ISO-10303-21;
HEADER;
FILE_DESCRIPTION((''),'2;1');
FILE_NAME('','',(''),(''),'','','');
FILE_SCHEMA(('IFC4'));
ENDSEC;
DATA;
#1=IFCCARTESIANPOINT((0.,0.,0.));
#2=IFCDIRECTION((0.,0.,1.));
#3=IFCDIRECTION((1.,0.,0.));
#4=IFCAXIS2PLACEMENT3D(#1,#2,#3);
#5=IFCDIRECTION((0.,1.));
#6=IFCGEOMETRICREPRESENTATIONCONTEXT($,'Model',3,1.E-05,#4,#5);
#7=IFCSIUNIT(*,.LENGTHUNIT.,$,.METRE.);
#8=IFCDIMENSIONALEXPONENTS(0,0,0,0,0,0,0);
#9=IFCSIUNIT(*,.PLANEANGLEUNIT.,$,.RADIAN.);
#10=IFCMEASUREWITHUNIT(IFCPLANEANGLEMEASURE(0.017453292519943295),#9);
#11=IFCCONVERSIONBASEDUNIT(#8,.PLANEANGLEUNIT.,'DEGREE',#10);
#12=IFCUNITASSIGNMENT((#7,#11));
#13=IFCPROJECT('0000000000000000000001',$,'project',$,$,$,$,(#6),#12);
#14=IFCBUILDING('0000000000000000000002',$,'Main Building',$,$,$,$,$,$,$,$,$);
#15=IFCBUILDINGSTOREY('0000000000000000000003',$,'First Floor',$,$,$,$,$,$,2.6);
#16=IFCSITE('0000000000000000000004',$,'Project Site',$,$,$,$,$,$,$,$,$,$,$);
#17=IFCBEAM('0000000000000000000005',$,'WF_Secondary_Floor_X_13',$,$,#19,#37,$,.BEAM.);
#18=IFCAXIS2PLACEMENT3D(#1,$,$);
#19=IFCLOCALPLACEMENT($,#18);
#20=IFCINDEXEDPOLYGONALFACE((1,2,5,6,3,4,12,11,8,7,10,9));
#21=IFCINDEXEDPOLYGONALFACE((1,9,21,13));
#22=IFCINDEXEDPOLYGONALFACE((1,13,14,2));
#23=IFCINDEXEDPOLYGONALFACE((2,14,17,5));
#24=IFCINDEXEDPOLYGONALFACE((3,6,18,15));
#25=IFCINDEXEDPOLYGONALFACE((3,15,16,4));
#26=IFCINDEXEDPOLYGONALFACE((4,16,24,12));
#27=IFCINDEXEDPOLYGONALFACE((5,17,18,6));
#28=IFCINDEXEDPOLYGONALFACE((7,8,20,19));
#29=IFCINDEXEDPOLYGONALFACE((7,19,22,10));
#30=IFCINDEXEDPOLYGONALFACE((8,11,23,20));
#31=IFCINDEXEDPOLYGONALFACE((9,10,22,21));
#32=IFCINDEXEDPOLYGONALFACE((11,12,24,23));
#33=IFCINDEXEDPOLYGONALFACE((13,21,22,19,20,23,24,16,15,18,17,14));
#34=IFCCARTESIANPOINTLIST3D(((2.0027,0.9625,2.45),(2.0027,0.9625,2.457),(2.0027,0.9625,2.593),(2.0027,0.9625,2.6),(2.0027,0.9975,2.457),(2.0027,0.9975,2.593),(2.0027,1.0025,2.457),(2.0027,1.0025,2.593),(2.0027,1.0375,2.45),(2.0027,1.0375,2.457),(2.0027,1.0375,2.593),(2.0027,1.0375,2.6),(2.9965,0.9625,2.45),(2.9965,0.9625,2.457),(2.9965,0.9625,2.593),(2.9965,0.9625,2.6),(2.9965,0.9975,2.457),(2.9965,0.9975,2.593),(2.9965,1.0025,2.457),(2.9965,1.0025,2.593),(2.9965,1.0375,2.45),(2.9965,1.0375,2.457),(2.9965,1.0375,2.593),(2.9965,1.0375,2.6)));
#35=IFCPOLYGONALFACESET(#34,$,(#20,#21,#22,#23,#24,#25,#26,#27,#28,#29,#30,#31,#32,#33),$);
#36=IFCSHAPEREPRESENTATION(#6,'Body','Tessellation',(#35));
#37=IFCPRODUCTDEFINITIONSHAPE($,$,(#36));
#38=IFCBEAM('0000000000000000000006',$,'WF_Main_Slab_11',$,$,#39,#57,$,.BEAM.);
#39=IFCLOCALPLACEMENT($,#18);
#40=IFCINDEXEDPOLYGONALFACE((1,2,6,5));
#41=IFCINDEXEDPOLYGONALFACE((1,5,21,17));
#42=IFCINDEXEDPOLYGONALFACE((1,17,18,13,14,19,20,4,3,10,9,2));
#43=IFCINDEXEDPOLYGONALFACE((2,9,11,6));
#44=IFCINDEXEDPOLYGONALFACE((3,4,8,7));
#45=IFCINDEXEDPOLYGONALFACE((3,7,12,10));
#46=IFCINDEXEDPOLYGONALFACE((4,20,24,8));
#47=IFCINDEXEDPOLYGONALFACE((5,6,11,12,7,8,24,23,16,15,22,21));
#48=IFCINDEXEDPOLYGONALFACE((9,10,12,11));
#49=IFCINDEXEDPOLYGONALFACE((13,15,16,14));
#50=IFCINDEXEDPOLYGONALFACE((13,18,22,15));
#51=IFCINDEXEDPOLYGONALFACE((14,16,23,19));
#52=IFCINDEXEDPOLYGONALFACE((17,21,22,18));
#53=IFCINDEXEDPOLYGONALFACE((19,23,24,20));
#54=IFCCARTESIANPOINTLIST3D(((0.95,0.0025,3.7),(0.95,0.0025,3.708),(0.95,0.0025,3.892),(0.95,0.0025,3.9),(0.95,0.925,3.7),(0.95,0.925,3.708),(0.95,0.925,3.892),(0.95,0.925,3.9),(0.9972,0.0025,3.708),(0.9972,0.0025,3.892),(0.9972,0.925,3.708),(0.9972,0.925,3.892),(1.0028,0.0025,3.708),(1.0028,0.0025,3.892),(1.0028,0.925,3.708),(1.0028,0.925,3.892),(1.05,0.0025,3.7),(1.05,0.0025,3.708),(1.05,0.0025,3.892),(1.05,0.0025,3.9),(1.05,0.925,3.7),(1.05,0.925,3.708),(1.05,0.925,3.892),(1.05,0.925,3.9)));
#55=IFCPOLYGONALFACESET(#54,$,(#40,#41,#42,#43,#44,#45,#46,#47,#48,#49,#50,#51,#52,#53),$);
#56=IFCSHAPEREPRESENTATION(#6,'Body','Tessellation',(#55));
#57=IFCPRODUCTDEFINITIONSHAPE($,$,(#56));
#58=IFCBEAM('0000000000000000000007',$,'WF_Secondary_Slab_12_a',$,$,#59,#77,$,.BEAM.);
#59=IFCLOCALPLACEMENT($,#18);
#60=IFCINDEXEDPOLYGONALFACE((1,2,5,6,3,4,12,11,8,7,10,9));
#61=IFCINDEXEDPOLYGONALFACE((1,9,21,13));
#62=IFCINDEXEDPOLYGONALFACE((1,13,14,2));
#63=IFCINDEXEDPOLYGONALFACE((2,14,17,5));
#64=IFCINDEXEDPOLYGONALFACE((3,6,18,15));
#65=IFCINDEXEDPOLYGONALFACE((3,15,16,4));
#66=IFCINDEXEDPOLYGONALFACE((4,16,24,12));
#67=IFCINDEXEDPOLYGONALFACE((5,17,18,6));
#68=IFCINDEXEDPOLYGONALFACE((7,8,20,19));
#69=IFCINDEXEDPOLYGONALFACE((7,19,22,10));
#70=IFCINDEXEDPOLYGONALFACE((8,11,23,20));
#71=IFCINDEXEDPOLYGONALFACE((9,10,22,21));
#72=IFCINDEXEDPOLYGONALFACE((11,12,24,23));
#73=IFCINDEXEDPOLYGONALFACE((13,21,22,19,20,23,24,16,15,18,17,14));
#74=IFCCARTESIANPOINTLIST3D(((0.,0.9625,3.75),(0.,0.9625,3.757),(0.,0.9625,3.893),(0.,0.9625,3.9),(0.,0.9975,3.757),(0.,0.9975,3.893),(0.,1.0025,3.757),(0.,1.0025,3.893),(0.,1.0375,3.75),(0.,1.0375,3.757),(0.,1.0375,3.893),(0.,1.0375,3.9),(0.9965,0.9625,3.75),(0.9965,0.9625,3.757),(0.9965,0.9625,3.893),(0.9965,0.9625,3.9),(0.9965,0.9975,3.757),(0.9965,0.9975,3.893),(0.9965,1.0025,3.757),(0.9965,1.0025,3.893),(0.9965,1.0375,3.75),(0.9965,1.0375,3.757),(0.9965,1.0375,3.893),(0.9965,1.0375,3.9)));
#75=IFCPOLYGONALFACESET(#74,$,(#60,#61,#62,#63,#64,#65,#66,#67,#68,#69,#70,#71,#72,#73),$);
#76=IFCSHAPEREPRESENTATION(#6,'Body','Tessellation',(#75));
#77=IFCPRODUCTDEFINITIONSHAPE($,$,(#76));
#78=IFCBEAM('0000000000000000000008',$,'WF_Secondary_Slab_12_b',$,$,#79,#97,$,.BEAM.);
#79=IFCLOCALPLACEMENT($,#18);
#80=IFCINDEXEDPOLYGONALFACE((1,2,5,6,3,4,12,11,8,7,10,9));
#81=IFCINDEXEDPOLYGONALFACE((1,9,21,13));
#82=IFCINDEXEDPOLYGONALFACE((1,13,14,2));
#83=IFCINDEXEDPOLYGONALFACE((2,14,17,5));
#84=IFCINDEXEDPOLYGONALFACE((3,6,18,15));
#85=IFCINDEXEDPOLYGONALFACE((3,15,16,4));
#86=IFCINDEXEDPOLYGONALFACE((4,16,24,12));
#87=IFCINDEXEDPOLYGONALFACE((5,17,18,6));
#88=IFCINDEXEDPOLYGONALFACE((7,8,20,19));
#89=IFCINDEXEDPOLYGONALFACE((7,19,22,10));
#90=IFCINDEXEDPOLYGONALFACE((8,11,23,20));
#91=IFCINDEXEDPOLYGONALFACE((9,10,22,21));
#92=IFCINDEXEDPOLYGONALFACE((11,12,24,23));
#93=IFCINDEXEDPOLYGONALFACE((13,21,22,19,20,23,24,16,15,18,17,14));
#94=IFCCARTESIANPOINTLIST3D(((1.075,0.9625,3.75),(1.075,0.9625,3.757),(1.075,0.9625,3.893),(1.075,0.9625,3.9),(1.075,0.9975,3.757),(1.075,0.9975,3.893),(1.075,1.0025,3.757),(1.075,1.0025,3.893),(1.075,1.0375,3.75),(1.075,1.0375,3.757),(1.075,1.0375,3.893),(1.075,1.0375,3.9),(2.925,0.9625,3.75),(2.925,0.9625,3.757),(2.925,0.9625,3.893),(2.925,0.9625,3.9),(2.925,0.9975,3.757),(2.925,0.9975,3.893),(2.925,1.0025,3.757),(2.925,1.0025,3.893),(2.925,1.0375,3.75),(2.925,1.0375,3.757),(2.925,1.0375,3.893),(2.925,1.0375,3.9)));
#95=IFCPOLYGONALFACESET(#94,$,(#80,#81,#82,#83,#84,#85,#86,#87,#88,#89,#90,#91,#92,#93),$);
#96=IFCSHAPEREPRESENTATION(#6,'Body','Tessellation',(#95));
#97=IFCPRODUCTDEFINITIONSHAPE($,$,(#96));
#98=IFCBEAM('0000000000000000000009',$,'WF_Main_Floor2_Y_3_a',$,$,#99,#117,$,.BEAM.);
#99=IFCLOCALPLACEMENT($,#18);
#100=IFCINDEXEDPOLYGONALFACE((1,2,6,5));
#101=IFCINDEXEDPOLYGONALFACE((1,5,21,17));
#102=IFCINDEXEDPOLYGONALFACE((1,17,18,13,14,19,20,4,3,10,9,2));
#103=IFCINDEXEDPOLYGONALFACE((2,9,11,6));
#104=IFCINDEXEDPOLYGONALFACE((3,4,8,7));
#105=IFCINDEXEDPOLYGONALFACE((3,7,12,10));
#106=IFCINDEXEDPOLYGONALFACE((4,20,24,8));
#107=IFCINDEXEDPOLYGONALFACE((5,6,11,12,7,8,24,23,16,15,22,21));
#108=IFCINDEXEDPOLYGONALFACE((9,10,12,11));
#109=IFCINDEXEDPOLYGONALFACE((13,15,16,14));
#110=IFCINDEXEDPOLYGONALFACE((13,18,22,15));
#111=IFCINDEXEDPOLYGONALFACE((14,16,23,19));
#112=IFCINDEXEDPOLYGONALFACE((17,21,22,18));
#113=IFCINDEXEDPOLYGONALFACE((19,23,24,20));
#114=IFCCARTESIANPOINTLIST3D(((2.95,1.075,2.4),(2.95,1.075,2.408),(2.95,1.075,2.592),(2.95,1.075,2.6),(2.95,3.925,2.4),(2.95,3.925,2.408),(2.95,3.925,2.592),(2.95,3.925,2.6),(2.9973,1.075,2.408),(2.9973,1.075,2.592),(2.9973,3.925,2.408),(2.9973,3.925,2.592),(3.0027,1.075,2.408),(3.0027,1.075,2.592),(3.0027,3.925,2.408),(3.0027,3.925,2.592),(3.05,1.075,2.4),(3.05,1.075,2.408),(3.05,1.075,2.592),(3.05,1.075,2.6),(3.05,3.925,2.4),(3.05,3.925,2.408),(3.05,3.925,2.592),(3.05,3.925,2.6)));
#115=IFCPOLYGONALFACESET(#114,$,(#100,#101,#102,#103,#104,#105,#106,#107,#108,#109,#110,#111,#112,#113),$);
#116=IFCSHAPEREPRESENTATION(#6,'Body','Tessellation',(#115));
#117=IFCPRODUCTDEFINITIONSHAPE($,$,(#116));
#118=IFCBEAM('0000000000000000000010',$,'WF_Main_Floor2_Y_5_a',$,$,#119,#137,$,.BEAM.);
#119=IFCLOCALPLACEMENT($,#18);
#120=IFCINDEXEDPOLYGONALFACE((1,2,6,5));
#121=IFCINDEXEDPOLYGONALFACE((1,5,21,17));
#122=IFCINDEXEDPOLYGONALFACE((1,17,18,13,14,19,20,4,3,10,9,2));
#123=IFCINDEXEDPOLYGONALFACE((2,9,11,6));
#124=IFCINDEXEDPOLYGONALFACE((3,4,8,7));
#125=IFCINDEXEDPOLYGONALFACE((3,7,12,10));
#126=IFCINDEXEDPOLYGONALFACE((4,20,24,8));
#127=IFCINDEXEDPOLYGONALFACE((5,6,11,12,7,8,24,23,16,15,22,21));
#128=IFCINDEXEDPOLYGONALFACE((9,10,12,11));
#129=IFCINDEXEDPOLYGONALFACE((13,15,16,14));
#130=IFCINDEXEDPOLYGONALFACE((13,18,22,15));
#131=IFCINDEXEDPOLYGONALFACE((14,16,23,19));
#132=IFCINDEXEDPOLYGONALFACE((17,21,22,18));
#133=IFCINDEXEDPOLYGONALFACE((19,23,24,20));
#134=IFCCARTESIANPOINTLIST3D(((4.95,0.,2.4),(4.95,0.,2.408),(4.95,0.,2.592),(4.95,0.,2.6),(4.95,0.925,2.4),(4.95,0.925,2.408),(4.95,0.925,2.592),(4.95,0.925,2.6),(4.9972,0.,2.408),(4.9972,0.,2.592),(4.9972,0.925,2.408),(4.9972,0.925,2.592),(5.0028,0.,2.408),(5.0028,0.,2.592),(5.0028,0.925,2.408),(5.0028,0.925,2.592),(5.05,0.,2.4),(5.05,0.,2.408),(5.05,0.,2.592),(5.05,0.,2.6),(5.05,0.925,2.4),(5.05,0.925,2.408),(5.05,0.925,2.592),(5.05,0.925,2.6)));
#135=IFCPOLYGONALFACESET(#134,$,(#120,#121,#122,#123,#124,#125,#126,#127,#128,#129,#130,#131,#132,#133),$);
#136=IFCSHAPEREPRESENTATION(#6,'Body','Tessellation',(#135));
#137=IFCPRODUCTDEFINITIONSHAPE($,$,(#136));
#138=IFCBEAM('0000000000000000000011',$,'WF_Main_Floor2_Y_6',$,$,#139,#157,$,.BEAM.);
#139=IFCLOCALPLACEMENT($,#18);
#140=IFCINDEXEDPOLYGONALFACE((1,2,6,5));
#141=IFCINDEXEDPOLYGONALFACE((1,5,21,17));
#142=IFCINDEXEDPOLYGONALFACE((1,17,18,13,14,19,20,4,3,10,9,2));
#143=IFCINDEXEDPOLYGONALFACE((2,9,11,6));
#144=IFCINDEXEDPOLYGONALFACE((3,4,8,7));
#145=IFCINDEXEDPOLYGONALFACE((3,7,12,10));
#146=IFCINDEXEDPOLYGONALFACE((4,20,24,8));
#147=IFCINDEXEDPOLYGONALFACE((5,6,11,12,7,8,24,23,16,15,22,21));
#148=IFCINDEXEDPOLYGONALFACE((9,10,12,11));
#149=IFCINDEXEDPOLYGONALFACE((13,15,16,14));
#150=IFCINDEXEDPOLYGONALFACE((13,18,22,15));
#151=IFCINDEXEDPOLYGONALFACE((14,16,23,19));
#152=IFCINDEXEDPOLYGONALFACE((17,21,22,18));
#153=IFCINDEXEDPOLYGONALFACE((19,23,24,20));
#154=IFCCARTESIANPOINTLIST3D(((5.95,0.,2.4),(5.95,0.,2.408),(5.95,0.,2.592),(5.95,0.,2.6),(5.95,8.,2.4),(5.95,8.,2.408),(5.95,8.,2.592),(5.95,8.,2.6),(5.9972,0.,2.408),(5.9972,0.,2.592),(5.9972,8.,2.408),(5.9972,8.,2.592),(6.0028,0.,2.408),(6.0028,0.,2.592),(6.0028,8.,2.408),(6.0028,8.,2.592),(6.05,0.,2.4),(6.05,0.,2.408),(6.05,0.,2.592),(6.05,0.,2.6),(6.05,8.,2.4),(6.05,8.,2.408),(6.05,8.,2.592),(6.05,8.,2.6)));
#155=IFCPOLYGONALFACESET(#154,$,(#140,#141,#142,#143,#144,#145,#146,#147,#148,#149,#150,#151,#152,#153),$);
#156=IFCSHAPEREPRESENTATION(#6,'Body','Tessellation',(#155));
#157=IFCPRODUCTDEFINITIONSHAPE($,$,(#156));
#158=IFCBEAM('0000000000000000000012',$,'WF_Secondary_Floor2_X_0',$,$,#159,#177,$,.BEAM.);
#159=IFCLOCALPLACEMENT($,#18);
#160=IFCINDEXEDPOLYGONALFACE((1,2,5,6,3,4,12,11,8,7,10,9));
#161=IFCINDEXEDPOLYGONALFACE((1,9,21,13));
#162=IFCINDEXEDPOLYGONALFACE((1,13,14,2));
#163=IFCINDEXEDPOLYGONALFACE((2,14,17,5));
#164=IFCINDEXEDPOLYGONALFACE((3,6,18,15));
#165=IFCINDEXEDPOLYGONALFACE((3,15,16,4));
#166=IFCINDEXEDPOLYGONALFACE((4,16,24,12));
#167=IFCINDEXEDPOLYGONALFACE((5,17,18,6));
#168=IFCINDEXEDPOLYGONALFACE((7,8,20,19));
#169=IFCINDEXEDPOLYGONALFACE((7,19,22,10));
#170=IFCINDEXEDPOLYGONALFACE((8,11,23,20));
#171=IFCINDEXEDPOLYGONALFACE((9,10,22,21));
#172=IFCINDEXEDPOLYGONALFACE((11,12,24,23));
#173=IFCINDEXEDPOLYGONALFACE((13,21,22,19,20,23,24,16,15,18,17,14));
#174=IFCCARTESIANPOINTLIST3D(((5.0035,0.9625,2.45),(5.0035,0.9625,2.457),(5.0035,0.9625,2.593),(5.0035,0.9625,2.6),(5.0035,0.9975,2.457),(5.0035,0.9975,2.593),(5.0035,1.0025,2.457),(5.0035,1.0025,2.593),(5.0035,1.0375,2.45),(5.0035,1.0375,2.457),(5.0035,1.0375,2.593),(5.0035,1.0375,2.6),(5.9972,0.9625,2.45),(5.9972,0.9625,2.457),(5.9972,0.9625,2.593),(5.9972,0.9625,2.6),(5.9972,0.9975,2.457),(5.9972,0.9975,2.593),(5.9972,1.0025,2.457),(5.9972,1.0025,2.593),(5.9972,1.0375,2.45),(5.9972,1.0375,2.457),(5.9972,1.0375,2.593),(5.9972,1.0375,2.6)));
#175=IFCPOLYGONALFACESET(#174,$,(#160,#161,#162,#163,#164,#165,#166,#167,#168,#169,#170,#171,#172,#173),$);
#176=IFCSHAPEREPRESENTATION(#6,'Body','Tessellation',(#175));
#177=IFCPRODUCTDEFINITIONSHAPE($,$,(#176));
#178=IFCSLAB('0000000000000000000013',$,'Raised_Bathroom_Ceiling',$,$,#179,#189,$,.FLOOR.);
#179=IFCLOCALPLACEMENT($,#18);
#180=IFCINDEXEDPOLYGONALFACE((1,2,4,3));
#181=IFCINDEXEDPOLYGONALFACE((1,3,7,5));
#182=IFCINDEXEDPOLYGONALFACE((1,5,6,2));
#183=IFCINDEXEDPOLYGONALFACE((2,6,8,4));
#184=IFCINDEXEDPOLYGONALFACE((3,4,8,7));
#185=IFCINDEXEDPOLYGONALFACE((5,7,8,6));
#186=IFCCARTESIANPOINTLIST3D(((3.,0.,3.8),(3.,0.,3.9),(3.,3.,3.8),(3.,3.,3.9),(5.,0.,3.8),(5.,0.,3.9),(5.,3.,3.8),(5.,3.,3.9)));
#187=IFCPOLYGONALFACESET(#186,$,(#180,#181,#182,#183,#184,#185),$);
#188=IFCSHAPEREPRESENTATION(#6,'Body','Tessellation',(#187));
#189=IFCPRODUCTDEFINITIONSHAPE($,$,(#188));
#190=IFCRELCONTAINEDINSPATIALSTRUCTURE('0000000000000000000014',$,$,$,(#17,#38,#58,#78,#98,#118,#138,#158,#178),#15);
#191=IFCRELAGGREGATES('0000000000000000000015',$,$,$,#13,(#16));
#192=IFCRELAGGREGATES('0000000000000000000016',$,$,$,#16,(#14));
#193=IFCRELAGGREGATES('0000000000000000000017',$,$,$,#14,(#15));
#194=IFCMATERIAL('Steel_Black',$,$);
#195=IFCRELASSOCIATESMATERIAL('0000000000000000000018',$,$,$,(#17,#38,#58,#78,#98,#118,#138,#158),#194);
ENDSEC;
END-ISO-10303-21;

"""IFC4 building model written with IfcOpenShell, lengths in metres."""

from ifc_helpers import new_model, entity, si_unit, converted_unit, direction, frame, frame_2d, origin, origin_with_axes, place, context, project, spatial, polyline, i_section, outline, extrude, material, element, save


model = new_model("IFC4")

# Units and contexts
model_context = context("Model", 3, precision=1e-05, world=origin_with_axes(), true_north=direction((0.0, 1.0)))
ifc_project = project(units=[si_unit("LENGTHUNIT", "METRE"), converted_unit("PLANEANGLEUNIT", "DEGREE", entity("IfcPlaneAngleMeasure", 0.017453292519943295), si_unit("PLANEANGLEUNIT", "RADIAN"), dimensions=[0, 0, 0, 0, 0, 0, 0])], contexts=[model_context])

# Site, building, storey
site = spatial("IfcSite", under=ifc_project, Name="Project Site")
building = spatial("IfcBuilding", under=site, Name="Main Building")
storey = spatial("IfcBuildingStorey", under=building, Name="First Floor", Elevation=2.6)

# Shared definitions
ifc_material = material(Name="Steel_Black")

# Beams
beam_1_placement = place(None, frame((2.0027, 1.0, 2.45), z_axis=(0.0, 0.0, 1.0), x_axis=(1.0, 0.0, 0.0)))
element("IfcBeam", 1, at=beam_1_placement, inside=storey, material=ifc_material, Name="WF_Secondary_Floor_X_13", PredefinedType="BEAM", context=model_context, shape_type="SweptSolid", body=[
    extrude(i_section(OverallWidth=0.075, OverallDepth=0.15, WebThickness=0.005, FlangeThickness=0.007, at=frame_2d((0.0, 0.075))), frame((0.0, 0.0, 0.0), z_axis=(1.0, 0.0, 0.0), x_axis=(0.0, 1.0, 0.0)), (0.0, 0.0, 1.0), 0.9938),
])
beam_2_placement = place(None, frame((1.0, 0.0025, 3.7), z_axis=(0.0, 0.0, 1.0), x_axis=(0.0, 1.0, 0.0)))
element("IfcBeam", 2, at=beam_2_placement, inside=storey, material=ifc_material, Name="WF_Main_Slab_11", PredefinedType="BEAM", context=model_context, shape_type="SweptSolid", body=[
    extrude(i_section(OverallWidth=0.1, OverallDepth=0.2, WebThickness=0.0055, FlangeThickness=0.008, at=frame_2d((0.0, 0.1))), frame((0.0, 0.0, 0.0), z_axis=(1.0, 0.0, 0.0), x_axis=(0.0, 1.0, 0.0)), (0.0, 0.0, 1.0), 0.9225),
])
beam_3_placement = place(None, frame((0.0, 1.0, 3.75), z_axis=(0.0, 0.0, 1.0), x_axis=(1.0, 0.0, 0.0)))
element("IfcBeam", 3, at=beam_3_placement, inside=storey, material=ifc_material, Name="WF_Secondary_Slab_12_a", PredefinedType="BEAM", context=model_context, shape_type="SweptSolid", body=[
    extrude(i_section(OverallWidth=0.075, OverallDepth=0.15, WebThickness=0.005, FlangeThickness=0.007, at=frame_2d((0.0, 0.075))), frame((0.0, 0.0, 0.0), z_axis=(1.0, 0.0, 0.0), x_axis=(0.0, 1.0, 0.0)), (0.0, 0.0, 1.0), 0.9965),
])
beam_4_placement = place(None, frame((1.075, 1.0, 3.75), z_axis=(0.0, 0.0, 1.0), x_axis=(1.0, 0.0, 0.0)))
element("IfcBeam", 4, at=beam_4_placement, inside=storey, material=ifc_material, Name="WF_Secondary_Slab_12_b", PredefinedType="BEAM", context=model_context, shape_type="SweptSolid", body=[
    extrude(i_section(OverallWidth=0.075, OverallDepth=0.15, WebThickness=0.005, FlangeThickness=0.007, at=frame_2d((0.0, 0.075))), frame((0.0, 0.0, 0.0), z_axis=(1.0, 0.0, 0.0), x_axis=(0.0, 1.0, 0.0)), (0.0, 0.0, 1.0), 1.85),
])
beam_5_placement = place(None, frame((3.0, 1.075, 2.4), z_axis=(0.0, 0.0, 1.0), x_axis=(0.0, 1.0, 0.0)))
element("IfcBeam", 5, at=beam_5_placement, inside=storey, material=ifc_material, Name="WF_Main_Floor2_Y_3_a", PredefinedType="BEAM", context=model_context, shape_type="SweptSolid", body=[
    extrude(i_section(OverallWidth=0.1, OverallDepth=0.2, WebThickness=0.0055, FlangeThickness=0.008, at=frame_2d((0.0, 0.1))), frame((0.0, 0.0, 0.0), z_axis=(1.0, 0.0, 0.0), x_axis=(0.0, 1.0, 0.0)), (0.0, 0.0, 1.0), 2.85),
])
beam_6_placement = place(None, frame((5.0, 0.0, 2.4), z_axis=(0.0, 0.0, 1.0), x_axis=(0.0, 1.0, 0.0)))
element("IfcBeam", 6, at=beam_6_placement, inside=storey, material=ifc_material, Name="WF_Main_Floor2_Y_5_a", PredefinedType="BEAM", context=model_context, shape_type="SweptSolid", body=[
    extrude(i_section(OverallWidth=0.1, OverallDepth=0.2, WebThickness=0.0055, FlangeThickness=0.008, at=frame_2d((0.0, 0.1))), frame((0.0, 0.0, 0.0), z_axis=(1.0, 0.0, 0.0), x_axis=(0.0, 1.0, 0.0)), (0.0, 0.0, 1.0), 0.925),
])
beam_7_placement = place(None, frame((6.0, 0.0, 2.4), z_axis=(0.0, 0.0, 1.0), x_axis=(0.0, 1.0, 0.0)))
element("IfcBeam", 7, at=beam_7_placement, inside=storey, material=ifc_material, Name="WF_Main_Floor2_Y_6", PredefinedType="BEAM", context=model_context, shape_type="SweptSolid", body=[
    extrude(i_section(OverallWidth=0.1, OverallDepth=0.2, WebThickness=0.0055, FlangeThickness=0.008, at=frame_2d((0.0, 0.1))), frame((0.0, 0.0, 0.0), z_axis=(1.0, 0.0, 0.0), x_axis=(0.0, 1.0, 0.0)), (0.0, 0.0, 1.0), 8.0),
])
beam_8_placement = place(None, frame((5.0035, 1.0, 2.45), z_axis=(0.0, 0.0, 1.0), x_axis=(1.0, 0.0, 0.0)))
element("IfcBeam", 8, at=beam_8_placement, inside=storey, material=ifc_material, Name="WF_Secondary_Floor2_X_0", PredefinedType="BEAM", context=model_context, shape_type="SweptSolid", body=[
    extrude(i_section(OverallWidth=0.075, OverallDepth=0.15, WebThickness=0.005, FlangeThickness=0.007, at=frame_2d((0.0, 0.075))), frame((0.0, 0.0, 0.0), z_axis=(1.0, 0.0, 0.0), x_axis=(0.0, 1.0, 0.0)), (0.0, 0.0, 1.0), 0.9938),
])

# Slab
slab_1_placement = place(None, frame((0.0, 0.0, 3.8), z_axis=(0.0, 0.0, 1.0), x_axis=(1.0, 0.0, 0.0)))
element("IfcSlab", 9, at=slab_1_placement, inside=storey, Name="Raised_Bathroom_Ceiling", PredefinedType="FLOOR", context=model_context, shape_type="SweptSolid", body=[
    extrude(outline(polyline([(3.0, 0.0), (5.0, 0.0), (5.0, 3.0), (3.0, 3.0), (3.0, 0.0)])), origin(), (0.0, 0.0, 1.0), 0.1),
])

save(model, "model.ifc")
